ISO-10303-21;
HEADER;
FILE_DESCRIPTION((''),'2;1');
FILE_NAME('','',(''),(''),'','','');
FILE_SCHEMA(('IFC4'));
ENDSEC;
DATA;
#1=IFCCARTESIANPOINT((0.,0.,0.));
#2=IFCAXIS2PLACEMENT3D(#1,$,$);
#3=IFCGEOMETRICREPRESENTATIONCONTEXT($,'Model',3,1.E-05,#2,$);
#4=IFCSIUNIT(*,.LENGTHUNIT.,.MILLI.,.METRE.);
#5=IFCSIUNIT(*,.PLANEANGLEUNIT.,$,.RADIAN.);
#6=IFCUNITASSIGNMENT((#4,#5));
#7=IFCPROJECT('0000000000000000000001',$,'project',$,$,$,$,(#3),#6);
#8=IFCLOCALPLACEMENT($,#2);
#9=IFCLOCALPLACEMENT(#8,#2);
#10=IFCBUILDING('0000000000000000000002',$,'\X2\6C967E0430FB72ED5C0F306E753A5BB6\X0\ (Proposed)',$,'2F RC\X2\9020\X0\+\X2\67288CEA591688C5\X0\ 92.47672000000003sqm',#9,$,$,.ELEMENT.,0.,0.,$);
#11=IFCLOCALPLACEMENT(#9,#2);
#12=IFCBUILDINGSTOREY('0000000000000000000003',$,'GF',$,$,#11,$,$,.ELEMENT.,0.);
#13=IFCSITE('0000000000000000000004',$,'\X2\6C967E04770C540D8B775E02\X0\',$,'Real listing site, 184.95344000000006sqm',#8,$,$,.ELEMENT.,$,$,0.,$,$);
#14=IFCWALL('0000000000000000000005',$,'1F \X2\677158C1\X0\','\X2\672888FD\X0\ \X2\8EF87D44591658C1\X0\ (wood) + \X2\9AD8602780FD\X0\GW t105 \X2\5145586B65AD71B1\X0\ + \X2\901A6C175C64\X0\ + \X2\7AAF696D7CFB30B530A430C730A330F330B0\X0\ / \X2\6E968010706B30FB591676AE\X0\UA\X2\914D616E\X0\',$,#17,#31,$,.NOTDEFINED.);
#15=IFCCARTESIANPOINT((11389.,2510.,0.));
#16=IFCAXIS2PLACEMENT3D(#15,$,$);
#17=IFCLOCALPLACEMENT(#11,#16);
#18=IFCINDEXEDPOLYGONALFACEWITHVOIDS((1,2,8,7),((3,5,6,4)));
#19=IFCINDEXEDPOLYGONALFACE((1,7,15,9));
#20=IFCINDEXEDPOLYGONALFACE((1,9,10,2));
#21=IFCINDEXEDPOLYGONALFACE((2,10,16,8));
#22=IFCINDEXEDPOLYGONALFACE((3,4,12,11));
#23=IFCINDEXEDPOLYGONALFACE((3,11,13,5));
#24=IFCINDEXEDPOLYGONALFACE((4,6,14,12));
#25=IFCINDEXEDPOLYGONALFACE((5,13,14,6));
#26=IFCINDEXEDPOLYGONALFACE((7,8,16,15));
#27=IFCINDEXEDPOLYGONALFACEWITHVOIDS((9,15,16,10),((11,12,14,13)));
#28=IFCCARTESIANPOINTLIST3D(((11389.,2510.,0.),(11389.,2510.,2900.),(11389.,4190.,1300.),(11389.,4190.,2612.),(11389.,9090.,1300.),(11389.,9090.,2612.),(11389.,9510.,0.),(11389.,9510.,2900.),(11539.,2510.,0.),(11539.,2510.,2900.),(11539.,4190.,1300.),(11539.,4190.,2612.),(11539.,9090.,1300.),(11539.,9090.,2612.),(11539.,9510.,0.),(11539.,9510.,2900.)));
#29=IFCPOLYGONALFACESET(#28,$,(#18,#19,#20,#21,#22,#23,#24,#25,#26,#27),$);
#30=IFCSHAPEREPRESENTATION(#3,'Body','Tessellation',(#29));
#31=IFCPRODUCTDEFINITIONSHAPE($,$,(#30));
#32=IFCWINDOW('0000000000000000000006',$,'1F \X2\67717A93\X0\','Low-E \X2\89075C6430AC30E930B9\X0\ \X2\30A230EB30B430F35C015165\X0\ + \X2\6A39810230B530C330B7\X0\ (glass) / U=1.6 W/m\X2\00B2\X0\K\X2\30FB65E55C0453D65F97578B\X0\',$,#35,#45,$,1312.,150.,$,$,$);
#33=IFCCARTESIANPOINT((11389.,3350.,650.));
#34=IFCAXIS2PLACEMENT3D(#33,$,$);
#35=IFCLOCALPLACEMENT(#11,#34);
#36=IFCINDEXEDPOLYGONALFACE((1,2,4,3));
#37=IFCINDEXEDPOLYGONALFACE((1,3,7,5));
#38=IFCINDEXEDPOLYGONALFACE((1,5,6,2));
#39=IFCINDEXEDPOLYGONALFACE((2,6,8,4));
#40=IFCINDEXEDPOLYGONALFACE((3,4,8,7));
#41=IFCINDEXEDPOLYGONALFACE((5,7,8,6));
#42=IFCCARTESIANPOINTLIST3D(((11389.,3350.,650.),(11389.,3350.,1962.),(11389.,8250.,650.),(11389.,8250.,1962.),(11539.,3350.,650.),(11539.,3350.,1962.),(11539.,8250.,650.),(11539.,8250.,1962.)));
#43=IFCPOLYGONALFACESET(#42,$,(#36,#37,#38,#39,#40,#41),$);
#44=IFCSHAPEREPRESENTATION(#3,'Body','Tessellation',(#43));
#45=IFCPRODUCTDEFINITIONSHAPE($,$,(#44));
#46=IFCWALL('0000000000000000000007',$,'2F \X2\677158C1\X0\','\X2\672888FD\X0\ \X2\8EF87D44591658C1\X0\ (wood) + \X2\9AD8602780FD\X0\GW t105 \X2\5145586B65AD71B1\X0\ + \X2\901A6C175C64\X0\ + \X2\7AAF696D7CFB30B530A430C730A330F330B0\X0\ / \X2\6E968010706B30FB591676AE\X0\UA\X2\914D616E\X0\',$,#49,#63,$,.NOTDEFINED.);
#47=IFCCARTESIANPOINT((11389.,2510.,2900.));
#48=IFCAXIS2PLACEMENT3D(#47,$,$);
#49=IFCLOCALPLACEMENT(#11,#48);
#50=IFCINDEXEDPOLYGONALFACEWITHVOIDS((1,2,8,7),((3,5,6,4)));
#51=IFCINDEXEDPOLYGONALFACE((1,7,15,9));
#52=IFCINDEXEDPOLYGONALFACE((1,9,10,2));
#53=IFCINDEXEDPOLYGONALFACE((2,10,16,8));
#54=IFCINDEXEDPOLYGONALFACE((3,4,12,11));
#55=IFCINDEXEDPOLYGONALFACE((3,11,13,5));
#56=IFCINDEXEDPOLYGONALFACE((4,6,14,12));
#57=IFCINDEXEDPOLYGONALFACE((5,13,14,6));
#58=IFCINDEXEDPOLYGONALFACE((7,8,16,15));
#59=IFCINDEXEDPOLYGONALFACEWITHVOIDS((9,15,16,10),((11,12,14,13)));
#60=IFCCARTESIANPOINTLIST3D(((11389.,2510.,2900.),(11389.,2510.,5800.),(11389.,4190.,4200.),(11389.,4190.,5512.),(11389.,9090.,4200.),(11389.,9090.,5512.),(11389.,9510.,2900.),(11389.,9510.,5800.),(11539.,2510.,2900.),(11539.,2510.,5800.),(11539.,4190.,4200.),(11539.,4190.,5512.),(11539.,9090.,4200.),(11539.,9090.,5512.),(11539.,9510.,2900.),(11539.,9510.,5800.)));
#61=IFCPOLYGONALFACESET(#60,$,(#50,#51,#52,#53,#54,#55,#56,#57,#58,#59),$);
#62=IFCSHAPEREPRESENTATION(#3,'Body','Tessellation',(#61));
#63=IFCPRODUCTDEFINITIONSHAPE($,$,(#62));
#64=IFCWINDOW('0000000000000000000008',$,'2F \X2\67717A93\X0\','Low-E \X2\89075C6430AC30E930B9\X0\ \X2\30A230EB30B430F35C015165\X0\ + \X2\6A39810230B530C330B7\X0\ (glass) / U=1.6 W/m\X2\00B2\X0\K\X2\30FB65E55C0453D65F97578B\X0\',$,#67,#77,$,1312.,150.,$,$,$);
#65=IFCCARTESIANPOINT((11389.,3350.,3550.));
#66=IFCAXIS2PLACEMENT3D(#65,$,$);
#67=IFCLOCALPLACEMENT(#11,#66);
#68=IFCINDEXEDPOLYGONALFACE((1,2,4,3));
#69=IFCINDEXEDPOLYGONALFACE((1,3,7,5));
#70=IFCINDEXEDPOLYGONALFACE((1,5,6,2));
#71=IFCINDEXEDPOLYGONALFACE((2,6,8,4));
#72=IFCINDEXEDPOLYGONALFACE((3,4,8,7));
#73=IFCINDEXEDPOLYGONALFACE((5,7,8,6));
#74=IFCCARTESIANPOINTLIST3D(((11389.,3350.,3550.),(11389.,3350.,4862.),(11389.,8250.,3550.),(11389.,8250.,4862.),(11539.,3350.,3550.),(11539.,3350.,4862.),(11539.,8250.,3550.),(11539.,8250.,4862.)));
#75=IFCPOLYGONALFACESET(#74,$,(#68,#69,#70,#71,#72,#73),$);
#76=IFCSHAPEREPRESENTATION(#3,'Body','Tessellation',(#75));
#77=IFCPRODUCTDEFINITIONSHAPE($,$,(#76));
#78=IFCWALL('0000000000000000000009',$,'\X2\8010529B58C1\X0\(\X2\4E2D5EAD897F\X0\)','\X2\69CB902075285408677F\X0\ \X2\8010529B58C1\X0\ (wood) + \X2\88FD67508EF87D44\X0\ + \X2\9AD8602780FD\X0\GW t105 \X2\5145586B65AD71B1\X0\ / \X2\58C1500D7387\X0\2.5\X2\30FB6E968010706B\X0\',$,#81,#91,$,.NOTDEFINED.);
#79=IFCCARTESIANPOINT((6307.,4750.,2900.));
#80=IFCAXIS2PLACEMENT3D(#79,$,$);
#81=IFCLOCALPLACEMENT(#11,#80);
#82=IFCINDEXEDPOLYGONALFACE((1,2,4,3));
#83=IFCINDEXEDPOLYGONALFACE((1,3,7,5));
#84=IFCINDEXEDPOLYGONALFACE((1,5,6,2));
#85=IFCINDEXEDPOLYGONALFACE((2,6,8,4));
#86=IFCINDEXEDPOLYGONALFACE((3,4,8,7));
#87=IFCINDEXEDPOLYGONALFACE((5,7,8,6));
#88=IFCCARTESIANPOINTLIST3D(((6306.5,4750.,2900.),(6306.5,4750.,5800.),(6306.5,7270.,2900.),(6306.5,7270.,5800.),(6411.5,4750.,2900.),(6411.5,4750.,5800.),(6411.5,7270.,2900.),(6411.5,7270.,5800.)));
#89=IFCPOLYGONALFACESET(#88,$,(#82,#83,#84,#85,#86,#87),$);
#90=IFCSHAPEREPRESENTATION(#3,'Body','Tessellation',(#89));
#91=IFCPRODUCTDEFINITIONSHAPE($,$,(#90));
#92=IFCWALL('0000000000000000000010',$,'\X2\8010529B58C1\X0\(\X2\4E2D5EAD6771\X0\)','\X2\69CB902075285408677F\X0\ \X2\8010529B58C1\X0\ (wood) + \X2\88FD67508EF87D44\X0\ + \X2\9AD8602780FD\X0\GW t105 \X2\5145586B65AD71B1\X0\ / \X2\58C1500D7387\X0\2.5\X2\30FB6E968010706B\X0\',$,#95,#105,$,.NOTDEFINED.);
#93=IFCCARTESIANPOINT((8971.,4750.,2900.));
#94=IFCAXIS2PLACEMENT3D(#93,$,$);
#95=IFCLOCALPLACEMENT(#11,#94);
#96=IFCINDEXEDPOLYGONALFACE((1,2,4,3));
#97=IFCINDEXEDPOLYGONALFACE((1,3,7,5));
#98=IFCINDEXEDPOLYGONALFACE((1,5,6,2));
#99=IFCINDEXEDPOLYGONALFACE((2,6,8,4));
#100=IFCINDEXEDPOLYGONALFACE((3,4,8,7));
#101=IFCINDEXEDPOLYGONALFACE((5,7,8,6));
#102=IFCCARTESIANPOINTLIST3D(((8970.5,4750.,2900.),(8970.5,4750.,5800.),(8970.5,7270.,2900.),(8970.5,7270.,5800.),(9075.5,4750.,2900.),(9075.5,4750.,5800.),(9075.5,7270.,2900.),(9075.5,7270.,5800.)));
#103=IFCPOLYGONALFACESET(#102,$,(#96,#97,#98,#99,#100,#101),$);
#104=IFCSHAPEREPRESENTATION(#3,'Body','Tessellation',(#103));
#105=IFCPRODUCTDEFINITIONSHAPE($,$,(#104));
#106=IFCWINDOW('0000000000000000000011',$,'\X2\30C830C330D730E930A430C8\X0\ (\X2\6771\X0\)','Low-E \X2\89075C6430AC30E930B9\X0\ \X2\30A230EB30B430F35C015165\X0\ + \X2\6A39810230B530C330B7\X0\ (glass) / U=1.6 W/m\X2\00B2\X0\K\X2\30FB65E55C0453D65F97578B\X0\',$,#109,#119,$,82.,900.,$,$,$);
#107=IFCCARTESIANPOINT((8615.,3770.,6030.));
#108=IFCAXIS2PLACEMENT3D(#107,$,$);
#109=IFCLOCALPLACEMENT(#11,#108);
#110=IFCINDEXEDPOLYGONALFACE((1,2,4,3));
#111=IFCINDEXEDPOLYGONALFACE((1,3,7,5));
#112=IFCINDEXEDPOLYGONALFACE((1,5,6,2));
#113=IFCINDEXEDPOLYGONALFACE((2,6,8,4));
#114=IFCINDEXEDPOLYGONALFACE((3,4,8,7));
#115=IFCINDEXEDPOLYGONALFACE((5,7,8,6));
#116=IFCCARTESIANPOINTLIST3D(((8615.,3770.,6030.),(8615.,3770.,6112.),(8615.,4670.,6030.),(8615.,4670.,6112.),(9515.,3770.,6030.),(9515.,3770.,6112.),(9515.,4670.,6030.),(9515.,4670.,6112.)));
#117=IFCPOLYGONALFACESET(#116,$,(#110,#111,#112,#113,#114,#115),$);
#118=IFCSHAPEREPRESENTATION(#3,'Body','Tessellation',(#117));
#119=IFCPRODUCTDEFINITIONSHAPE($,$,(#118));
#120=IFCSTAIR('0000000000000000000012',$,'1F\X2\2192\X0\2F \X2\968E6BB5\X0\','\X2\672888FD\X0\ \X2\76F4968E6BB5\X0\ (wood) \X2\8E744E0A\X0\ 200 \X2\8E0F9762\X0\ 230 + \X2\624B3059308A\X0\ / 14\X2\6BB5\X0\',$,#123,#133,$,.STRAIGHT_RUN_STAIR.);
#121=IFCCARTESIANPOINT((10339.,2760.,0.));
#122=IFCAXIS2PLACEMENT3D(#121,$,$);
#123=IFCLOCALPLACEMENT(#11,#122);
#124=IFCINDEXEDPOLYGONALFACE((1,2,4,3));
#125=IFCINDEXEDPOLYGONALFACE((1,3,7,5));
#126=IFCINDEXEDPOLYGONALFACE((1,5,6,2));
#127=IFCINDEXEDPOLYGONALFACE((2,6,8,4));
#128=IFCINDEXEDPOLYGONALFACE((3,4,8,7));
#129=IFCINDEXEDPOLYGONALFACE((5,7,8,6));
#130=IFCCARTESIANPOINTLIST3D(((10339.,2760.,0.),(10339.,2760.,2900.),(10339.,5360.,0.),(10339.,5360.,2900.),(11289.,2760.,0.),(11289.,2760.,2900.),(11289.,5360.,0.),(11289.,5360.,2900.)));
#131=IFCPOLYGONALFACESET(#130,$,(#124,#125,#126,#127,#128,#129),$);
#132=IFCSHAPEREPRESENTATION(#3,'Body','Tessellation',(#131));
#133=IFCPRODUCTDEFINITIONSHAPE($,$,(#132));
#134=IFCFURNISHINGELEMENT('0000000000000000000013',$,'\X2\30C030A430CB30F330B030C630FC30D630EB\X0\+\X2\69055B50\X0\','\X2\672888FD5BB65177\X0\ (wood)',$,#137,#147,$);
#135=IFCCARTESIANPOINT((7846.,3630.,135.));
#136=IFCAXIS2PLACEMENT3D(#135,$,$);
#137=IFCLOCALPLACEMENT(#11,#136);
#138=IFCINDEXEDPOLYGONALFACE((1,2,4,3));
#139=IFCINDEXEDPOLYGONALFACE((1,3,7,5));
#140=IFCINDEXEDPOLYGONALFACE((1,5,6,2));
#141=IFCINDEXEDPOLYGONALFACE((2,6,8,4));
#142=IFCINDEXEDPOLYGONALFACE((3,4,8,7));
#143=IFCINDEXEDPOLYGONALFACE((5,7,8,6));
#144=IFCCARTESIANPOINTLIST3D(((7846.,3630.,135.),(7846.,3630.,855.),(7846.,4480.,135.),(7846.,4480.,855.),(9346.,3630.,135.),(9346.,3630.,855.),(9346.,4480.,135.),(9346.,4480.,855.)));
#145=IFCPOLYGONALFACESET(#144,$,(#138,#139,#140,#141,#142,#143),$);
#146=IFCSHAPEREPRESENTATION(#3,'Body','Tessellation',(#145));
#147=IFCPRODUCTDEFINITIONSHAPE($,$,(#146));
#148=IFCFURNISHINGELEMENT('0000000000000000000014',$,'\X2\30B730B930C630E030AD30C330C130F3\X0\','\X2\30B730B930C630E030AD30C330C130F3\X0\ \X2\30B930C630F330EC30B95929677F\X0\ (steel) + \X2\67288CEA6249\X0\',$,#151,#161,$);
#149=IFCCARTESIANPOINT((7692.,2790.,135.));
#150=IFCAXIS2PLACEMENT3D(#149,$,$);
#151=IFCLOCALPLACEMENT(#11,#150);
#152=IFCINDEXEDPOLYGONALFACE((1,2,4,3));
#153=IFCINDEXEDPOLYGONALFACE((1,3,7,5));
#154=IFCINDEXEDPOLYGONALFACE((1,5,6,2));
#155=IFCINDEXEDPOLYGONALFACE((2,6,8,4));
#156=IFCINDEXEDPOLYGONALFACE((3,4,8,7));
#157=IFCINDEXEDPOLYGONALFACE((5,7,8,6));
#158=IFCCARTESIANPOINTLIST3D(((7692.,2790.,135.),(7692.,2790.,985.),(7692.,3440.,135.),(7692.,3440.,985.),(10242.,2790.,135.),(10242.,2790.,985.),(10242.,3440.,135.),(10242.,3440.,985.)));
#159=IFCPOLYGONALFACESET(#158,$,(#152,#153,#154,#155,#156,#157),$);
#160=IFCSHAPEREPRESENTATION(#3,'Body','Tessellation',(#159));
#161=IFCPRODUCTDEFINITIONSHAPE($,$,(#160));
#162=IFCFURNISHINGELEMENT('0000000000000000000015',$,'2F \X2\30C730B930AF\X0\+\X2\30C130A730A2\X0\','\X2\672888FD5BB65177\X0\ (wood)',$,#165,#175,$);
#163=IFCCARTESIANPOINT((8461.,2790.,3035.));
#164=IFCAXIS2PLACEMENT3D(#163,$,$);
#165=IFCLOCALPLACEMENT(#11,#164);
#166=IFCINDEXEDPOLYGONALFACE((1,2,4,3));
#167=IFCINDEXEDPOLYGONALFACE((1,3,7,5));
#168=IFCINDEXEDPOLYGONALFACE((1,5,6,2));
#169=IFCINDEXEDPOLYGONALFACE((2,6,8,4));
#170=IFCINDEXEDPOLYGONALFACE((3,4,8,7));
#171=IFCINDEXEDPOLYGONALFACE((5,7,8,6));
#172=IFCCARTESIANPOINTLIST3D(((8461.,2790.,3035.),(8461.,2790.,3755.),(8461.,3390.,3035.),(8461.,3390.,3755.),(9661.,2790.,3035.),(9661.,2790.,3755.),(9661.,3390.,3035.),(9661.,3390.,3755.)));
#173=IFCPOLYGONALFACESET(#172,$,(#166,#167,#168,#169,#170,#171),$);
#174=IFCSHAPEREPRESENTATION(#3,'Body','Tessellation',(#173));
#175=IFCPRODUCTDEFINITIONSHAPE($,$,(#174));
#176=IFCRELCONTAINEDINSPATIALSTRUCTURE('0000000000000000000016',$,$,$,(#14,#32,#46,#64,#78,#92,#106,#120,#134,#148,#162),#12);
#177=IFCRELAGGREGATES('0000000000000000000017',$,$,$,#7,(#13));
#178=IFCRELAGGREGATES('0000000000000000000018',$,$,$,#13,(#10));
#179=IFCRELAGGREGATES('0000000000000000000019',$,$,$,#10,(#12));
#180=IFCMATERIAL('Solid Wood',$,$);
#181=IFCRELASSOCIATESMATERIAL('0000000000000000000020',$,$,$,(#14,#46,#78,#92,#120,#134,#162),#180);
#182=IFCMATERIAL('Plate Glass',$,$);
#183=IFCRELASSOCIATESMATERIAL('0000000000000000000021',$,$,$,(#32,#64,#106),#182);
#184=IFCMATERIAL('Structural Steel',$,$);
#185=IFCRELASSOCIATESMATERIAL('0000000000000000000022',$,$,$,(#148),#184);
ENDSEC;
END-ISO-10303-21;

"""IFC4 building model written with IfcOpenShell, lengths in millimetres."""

from ifc_helpers import new_model, si_unit, frame, frame_2d, origin, place, context, project, spatial, rectangle, extrude, material, element, fill, save


model = new_model("IFC4")

# Units and contexts
model_context = context("Model", 3, precision=1e-05, world=origin())
ifc_project = project(units=[si_unit("LENGTHUNIT", "METRE", prefix="MILLI"), si_unit("PLANEANGLEUNIT", "RADIAN")], contexts=[model_context])

# Site, building, storey
site_placement = place(None, origin())
site = spatial("IfcSite", under=ifc_project, at=site_placement, Name="沖縄県名護市", ObjectType="Real listing site, 184.95344000000006sqm", CompositionType="ELEMENT", RefElevation=0.0)
building_placement = place(site_placement, origin())
building = spatial("IfcBuilding", under=site, at=building_placement, Name="沖縄・狭小の町家 (Proposed)", ObjectType="2F RC造+木質外装 92.47672000000003sqm", CompositionType="ELEMENT", ElevationOfRefHeight=0.0, ElevationOfTerrain=0.0)
storey_placement = place(building_placement, origin())
storey = spatial("IfcBuildingStorey", under=building, at=storey_placement, Name="GF", CompositionType="ELEMENT", Elevation=0.0)

# Shared definitions
ifc_material_1 = material(Name="Solid Wood")

# Wall, opening, window
wall_1_placement = place(storey_placement, frame((11389.0, 2510.0, 0.0)))
wall_1 = element("IfcWall", 1, at=wall_1_placement, inside=storey, material=ifc_material_1, Name="1F 東壁", Description="木製 軸組外壁 (wood) + 高性能GW t105 充填断熱 + 通気層 + 窯業系サイディング / 準耐火・外皮UA配慮", PredefinedType="NOTDEFINED", context=model_context, shape_type="SweptSolid", body=[
    extrude(rectangle(XDim=150.0, YDim=7000.0, at=frame_2d((75.0, 3500.0))), frame((11389.0, 2510.0, 0.0)), (0.0, 0.0, 1.0), 2900.0),
])
opening_1_placement = place(storey_placement, frame((11389.0, 3350.0, 650.0)))
opening_1 = element("IfcOpeningElement", 2, at=opening_1_placement, cuts=wall_1, PredefinedType="NOTDEFINED", context=model_context, shape_type="SweptSolid", body=[
    extrude(rectangle(XDim=150.0, YDim=4900.0, at=frame_2d((75.0, 2450.0))), frame((11389.0, 3350.0, 650.0)), (0.0, 0.0, 1.0), 1312.0),
])
ifc_material_2 = material(Name="Plate Glass")
window_1_placement = place(storey_placement, frame((11389.0, 3350.0, 650.0)))
window_1 = element("IfcWindow", 3, at=window_1_placement, inside=storey, material=ifc_material_2, Name="1F 東窓", Description="Low-E 複層ガラス アルゴン封入 + 樹脂サッシ (glass) / U=1.6 W/m²K・日射取得型", OverallHeight=1312.0, OverallWidth=150.0, context=model_context, shape_type="SweptSolid", body=[
    extrude(rectangle(XDim=150.0, YDim=4900.0, at=frame_2d((75.0, 2450.0))), frame((11389.0, 3350.0, 650.0)), (0.0, 0.0, 1.0), 1312.0),
])
fill(opening_1, window_1)

# Wall, opening, window
wall_2_placement = place(storey_placement, frame((11389.0, 2510.0, 2900.0)))
wall_2 = element("IfcWall", 4, at=wall_2_placement, inside=storey, material=ifc_material_1, Name="2F 東壁", Description="木製 軸組外壁 (wood) + 高性能GW t105 充填断熱 + 通気層 + 窯業系サイディング / 準耐火・外皮UA配慮", PredefinedType="NOTDEFINED", context=model_context, shape_type="SweptSolid", body=[
    extrude(rectangle(XDim=150.0, YDim=7000.0, at=frame_2d((75.0, 3500.0))), frame((11389.0, 2510.0, 2900.0)), (0.0, 0.0, 1.0), 2900.0),
])
opening_2_placement = place(storey_placement, frame((11389.0, 3350.0, 3550.0)))
opening_2 = element("IfcOpeningElement", 5, at=opening_2_placement, cuts=wall_2, PredefinedType="NOTDEFINED", context=model_context, shape_type="SweptSolid", body=[
    extrude(rectangle(XDim=150.0, YDim=4900.0, at=frame_2d((75.0, 2450.0))), frame((11389.0, 3350.0, 3550.0)), (0.0, 0.0, 1.0), 1312.0),
])
window_2_placement = place(storey_placement, frame((11389.0, 3350.0, 3550.0)))
window_2 = element("IfcWindow", 6, at=window_2_placement, inside=storey, material=ifc_material_2, Name="2F 東窓", Description="Low-E 複層ガラス アルゴン封入 + 樹脂サッシ (glass) / U=1.6 W/m²K・日射取得型", OverallHeight=1312.0, OverallWidth=150.0, context=model_context, shape_type="SweptSolid", body=[
    extrude(rectangle(XDim=150.0, YDim=4900.0, at=frame_2d((75.0, 2450.0))), frame((11389.0, 3350.0, 3550.0)), (0.0, 0.0, 1.0), 1312.0),
])
fill(opening_2, window_2)

# Walls
wall_3_placement = place(storey_placement, frame((6307.0, 4750.0, 2900.0)))
element("IfcWall", 7, at=wall_3_placement, inside=storey, material=ifc_material_1, Name="耐力壁(中庭西)", Description="構造用合板 耐力壁 (wood) + 製材軸組 + 高性能GW t105 充填断熱 / 壁倍率2.5・準耐火", PredefinedType="NOTDEFINED", context=model_context, shape_type="SweptSolid", body=[
    extrude(rectangle(XDim=105.0, YDim=2520.0, at=frame_2d((52.0, 1260.0))), frame((6307.0, 4750.0, 2900.0)), (0.0, 0.0, 1.0), 2900.0),
])
wall_4_placement = place(storey_placement, frame((8971.0, 4750.0, 2900.0)))
element("IfcWall", 8, at=wall_4_placement, inside=storey, material=ifc_material_1, Name="耐力壁(中庭東)", Description="構造用合板 耐力壁 (wood) + 製材軸組 + 高性能GW t105 充填断熱 / 壁倍率2.5・準耐火", PredefinedType="NOTDEFINED", context=model_context, shape_type="SweptSolid", body=[
    extrude(rectangle(XDim=105.0, YDim=2520.0, at=frame_2d((52.0, 1260.0))), frame((8971.0, 4750.0, 2900.0)), (0.0, 0.0, 1.0), 2900.0),
])

# Window
window_3_placement = place(storey_placement, frame((8615.0, 3770.0, 6030.0)))
element("IfcWindow", 9, at=window_3_placement, inside=storey, material=ifc_material_2, Name="トップライト (東)", Description="Low-E 複層ガラス アルゴン封入 + 樹脂サッシ (glass) / U=1.6 W/m²K・日射取得型", OverallHeight=82.0, OverallWidth=900.0, context=model_context, shape_type="SweptSolid", body=[
    extrude(rectangle(XDim=900.0, YDim=900.0, at=frame_2d((450.0, 450.0))), frame((8615.0, 3770.0, 6030.0)), (0.0, 0.0, 1.0), 82.0),
])

# Stair
stair_placement = place(storey_placement, frame((10339.0, 2760.0, 0.0)))
element("IfcStair", 10, at=stair_placement, inside=storey, material=ifc_material_1, Name="1F→2F 階段", Description="木製 直階段 (wood) 蹴上 200 踏面 230 + 手すり / 14段", PredefinedType="STRAIGHT_RUN_STAIR", context=model_context, shape_type="SweptSolid", body=[
    extrude(rectangle(XDim=950.0, YDim=2600.0, at=frame_2d((475.0, 1300.0))), frame((10339.0, 2760.0, 0.0)), (0.0, 0.0, 1.0), 2900.0),
])

# Furnishing elements
furnishing_1_placement = place(storey_placement, frame((7846.0, 3630.0, 135.0)))
element("IfcFurnishingElement", 11, at=furnishing_1_placement, inside=storey, material=ifc_material_1, Name="ダイニングテーブル+椅子", Description="木製家具 (wood)", context=model_context, shape_type="SweptSolid", body=[
    extrude(rectangle(XDim=1500.0, YDim=850.0, at=frame_2d((750.0, 425.0))), frame((7846.0, 3630.0, 135.0)), (0.0, 0.0, 1.0), 720.0),
])
ifc_material_3 = material(Name="Structural Steel")
furnishing_2_placement = place(storey_placement, frame((7692.0, 2790.0, 135.0)))
element("IfcFurnishingElement", 12, at=furnishing_2_placement, inside=storey, material=ifc_material_3, Name="システムキッチン", Description="システムキッチン ステンレス天板 (steel) + 木質扉", context=model_context, shape_type="SweptSolid", body=[
    extrude(rectangle(XDim=2550.0, YDim=650.0, at=frame_2d((1275.0, 325.0))), frame((7692.0, 2790.0, 135.0)), (0.0, 0.0, 1.0), 850.0),
])
furnishing_3_placement = place(storey_placement, frame((8461.0, 2790.0, 3035.0)))
element("IfcFurnishingElement", 13, at=furnishing_3_placement, inside=storey, material=ifc_material_1, Name="2F デスク+チェア", Description="木製家具 (wood)", context=model_context, shape_type="SweptSolid", body=[
    extrude(rectangle(XDim=1200.0, YDim=600.0, at=frame_2d((600.0, 300.0))), frame((8461.0, 2790.0, 3035.0)), (0.0, 0.0, 1.0), 720.0),
])

save(model, "model.ifc")
